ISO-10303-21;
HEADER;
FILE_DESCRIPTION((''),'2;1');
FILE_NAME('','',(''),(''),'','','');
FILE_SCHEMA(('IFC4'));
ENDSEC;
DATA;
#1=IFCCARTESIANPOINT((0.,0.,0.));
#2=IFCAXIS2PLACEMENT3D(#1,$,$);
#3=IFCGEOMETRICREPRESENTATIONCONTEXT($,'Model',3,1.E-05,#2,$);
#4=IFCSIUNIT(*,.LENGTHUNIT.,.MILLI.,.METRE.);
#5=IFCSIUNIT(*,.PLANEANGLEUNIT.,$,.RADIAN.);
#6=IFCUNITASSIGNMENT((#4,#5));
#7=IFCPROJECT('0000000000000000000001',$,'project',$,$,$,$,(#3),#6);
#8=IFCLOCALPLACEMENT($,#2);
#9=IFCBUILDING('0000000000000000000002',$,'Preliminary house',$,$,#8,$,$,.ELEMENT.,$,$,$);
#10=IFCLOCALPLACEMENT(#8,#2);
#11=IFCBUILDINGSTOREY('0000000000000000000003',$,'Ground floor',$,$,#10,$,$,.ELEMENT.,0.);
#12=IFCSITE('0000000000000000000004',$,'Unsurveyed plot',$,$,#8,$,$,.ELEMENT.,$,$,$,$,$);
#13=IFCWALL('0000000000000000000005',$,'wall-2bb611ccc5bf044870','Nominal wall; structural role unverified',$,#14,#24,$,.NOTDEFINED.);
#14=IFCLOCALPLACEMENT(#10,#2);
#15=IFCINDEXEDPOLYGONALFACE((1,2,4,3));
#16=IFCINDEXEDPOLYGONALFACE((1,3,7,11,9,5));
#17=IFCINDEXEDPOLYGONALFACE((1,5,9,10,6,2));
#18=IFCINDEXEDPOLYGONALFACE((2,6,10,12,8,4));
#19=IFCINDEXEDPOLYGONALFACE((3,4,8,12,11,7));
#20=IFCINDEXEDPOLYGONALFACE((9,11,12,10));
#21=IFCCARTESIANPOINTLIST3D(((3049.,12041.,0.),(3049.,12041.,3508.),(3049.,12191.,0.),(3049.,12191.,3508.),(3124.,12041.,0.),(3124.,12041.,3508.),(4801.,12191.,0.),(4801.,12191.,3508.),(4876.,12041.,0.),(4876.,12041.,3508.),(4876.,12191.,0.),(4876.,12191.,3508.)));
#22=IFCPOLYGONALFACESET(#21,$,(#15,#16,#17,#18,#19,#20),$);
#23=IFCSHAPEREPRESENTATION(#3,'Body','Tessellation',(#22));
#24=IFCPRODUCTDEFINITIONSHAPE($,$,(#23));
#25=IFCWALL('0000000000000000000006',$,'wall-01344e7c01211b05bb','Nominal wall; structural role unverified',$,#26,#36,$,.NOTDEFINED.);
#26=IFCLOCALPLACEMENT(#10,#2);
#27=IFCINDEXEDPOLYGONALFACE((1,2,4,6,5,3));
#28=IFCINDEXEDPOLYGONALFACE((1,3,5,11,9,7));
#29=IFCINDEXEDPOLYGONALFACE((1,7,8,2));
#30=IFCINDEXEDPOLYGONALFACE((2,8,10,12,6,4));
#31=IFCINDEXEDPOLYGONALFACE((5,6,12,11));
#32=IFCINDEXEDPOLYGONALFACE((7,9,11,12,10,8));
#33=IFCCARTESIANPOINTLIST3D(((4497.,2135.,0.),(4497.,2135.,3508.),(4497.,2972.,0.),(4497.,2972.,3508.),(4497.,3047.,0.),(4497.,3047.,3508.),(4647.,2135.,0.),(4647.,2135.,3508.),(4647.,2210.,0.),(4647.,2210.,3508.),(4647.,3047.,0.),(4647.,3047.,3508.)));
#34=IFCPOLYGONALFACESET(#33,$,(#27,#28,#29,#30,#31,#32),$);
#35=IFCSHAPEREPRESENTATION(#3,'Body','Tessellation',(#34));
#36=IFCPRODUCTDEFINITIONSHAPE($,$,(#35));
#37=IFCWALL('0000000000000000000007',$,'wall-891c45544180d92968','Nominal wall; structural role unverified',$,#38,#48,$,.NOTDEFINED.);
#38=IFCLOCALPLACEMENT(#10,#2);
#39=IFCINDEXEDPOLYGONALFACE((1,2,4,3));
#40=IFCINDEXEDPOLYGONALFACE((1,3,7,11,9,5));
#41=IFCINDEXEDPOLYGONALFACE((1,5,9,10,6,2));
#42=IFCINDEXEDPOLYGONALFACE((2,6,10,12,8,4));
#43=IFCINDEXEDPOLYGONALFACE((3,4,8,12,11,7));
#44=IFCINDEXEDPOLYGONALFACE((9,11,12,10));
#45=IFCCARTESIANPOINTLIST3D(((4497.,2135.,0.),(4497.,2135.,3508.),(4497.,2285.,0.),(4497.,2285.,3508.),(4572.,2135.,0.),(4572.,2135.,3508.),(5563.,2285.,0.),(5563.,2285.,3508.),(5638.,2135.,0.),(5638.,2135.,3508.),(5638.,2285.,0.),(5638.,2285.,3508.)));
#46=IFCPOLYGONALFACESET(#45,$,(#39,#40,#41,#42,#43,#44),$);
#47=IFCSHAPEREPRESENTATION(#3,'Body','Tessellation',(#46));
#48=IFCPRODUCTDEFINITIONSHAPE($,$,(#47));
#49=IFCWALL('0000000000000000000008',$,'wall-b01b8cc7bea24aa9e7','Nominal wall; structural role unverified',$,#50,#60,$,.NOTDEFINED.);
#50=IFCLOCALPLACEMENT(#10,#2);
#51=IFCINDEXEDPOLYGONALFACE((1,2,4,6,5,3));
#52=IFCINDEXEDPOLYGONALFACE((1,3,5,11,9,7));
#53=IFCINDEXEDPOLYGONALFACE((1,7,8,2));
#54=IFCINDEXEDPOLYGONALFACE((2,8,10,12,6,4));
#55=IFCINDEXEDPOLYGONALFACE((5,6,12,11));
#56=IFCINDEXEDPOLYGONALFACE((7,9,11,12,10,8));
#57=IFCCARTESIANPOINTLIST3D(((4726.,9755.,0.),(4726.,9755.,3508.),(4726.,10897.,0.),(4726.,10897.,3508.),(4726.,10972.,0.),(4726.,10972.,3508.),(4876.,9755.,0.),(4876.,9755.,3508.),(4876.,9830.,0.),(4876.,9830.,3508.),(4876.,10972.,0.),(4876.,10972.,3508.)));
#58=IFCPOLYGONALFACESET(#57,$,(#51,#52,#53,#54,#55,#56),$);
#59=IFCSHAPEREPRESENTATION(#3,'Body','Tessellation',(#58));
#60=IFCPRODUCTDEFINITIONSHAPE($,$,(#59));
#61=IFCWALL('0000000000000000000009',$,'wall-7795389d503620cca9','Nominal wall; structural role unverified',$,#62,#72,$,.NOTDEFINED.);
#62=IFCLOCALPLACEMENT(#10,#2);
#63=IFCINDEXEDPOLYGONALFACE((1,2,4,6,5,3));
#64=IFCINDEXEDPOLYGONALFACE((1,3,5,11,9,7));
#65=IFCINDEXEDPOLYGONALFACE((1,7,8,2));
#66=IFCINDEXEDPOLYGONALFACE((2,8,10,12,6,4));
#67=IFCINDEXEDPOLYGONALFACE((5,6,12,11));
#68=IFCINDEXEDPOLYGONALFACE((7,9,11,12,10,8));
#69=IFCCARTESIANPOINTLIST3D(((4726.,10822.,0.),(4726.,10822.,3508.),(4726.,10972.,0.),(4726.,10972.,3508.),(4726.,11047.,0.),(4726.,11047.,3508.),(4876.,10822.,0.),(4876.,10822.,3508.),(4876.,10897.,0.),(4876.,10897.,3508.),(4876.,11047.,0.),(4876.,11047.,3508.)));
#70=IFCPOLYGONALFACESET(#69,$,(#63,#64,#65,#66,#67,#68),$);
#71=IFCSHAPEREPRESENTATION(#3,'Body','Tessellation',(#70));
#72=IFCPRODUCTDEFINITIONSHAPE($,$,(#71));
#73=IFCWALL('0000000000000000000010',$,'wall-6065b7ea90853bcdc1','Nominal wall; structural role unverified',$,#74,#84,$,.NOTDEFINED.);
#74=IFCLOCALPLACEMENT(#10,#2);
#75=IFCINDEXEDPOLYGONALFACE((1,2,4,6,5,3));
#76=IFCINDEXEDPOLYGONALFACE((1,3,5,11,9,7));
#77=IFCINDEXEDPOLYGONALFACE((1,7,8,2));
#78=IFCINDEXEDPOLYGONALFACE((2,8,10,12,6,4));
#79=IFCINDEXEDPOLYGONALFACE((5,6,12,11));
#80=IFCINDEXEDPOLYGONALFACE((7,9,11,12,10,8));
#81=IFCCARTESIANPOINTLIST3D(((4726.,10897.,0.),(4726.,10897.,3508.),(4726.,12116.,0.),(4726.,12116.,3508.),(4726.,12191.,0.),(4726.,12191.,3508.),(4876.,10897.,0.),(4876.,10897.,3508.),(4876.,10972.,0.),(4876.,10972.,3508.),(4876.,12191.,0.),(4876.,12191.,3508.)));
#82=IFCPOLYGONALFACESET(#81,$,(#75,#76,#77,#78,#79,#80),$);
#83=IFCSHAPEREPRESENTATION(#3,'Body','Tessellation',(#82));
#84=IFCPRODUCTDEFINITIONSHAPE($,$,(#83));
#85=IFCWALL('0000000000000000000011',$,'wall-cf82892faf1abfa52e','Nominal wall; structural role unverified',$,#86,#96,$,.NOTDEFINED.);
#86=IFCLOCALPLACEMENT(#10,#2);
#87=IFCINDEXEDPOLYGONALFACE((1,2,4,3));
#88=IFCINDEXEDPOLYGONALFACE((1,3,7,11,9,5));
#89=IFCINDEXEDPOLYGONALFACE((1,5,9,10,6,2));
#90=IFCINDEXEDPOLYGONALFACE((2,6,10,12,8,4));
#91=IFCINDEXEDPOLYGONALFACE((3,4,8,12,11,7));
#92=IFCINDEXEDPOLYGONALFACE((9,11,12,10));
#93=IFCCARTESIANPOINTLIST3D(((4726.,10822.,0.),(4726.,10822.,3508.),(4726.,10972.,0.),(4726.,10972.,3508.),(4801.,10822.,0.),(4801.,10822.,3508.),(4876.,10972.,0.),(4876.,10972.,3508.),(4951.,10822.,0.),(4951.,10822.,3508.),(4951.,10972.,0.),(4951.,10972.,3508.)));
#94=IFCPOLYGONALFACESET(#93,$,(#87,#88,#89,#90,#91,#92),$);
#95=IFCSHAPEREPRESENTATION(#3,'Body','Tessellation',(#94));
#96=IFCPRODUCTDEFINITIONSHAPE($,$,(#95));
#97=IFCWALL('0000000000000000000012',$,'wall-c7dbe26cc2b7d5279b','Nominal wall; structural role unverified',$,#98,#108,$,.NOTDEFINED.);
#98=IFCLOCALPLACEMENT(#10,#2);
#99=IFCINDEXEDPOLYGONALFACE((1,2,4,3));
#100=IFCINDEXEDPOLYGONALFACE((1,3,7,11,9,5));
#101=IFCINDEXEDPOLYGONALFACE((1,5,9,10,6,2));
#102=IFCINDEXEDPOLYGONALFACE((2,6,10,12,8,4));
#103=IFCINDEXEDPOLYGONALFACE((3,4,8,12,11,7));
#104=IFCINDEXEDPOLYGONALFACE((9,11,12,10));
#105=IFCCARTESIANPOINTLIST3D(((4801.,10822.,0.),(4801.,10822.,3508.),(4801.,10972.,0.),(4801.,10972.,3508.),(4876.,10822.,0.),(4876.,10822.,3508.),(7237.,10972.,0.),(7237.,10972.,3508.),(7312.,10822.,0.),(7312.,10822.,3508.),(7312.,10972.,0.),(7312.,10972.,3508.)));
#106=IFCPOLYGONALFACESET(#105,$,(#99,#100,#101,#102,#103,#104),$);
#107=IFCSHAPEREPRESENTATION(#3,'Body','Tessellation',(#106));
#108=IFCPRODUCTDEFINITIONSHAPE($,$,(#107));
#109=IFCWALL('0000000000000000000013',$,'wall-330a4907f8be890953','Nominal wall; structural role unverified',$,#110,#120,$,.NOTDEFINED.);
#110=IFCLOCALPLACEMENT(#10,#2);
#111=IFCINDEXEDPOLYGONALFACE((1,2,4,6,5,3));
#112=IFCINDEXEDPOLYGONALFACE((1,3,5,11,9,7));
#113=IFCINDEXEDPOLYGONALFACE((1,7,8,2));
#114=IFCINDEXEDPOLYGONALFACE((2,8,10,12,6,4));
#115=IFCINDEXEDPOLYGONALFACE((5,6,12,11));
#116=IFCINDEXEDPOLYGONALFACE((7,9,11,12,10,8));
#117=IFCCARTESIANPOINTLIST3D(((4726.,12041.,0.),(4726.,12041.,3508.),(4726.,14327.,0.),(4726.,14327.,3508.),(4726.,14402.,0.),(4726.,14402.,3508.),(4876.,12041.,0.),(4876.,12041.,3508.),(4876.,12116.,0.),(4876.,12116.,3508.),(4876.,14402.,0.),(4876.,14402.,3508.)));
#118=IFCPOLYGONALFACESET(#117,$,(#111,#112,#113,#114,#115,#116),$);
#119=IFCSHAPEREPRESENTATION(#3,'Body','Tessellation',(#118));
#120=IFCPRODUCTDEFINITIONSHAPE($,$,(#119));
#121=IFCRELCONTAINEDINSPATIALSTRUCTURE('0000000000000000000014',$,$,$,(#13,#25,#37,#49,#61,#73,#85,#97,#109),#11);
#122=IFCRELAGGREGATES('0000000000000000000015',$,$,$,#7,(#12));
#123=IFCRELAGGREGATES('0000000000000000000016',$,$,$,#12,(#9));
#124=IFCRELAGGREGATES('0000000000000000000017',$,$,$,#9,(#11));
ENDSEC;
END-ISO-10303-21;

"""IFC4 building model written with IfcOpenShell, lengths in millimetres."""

from ifc_helpers import new_model, si_unit, origin, place, context, project, spatial, polyline, outline, extrude, element, save


model = new_model("IFC4")

# Units and contexts
model_context = context("Model", 3, precision=1e-05, world=origin())
ifc_project = project(units=[si_unit("LENGTHUNIT", "METRE", prefix="MILLI"), si_unit("PLANEANGLEUNIT", "RADIAN")], contexts=[model_context])

# Site, building, storey
placement_1 = place(None, origin())
site = spatial("IfcSite", under=ifc_project, at=placement_1, Name="Unsurveyed plot", CompositionType="ELEMENT")
building = spatial("IfcBuilding", under=site, at=placement_1, Name="Preliminary house", CompositionType="ELEMENT")
placement_2 = place(placement_1, origin())
storey = spatial("IfcBuildingStorey", under=building, at=placement_2, Name="Ground floor", CompositionType="ELEMENT", Elevation=0.0)

# Wall
element("IfcWall", 1, at=placement_2, inside=storey, Name="wall-2bb611ccc5bf044870", Description="Nominal wall; structural role unverified", PredefinedType="NOTDEFINED", context=model_context, shape_type="SweptSolid", body=[
    extrude(outline(polyline([(4801.0, 12191.0), (4876.0, 12191.0), (4876.0, 12041.0), (3124.0, 12041.0), (3049.0, 12041.0), (3049.0, 12191.0), (4801.0, 12191.0)])), origin(), (0.0, 0.0, 1.0), 3508.0),
])

# Walls
element("IfcWall", 2, at=placement_2, inside=storey, Name="wall-01344e7c01211b05bb", Description="Nominal wall; structural role unverified", PredefinedType="NOTDEFINED", context=model_context, shape_type="SweptSolid", body=[
    extrude(outline(polyline([(4497.0, 2972.0), (4497.0, 3047.0), (4647.0, 3047.0), (4647.0, 2210.0), (4647.0, 2135.0), (4497.0, 2135.0), (4497.0, 2972.0)])), origin(), (0.0, 0.0, 1.0), 3508.0),
])
element("IfcWall", 3, at=placement_2, inside=storey, Name="wall-891c45544180d92968", Description="Nominal wall; structural role unverified", PredefinedType="NOTDEFINED", context=model_context, shape_type="SweptSolid", body=[
    extrude(outline(polyline([(5563.0, 2285.0), (5638.0, 2285.0), (5638.0, 2135.0), (4572.0, 2135.0), (4497.0, 2135.0), (4497.0, 2285.0), (5563.0, 2285.0)])), origin(), (0.0, 0.0, 1.0), 3508.0),
])
element("IfcWall", 4, at=placement_2, inside=storey, Name="wall-b01b8cc7bea24aa9e7", Description="Nominal wall; structural role unverified", PredefinedType="NOTDEFINED", context=model_context, shape_type="SweptSolid", body=[
    extrude(outline(polyline([(4726.0, 10897.0), (4726.0, 10972.0), (4876.0, 10972.0), (4876.0, 9830.0), (4876.0, 9755.0), (4726.0, 9755.0), (4726.0, 10897.0)])), origin(), (0.0, 0.0, 1.0), 3508.0),
])

# Walls
element("IfcWall", 5, at=placement_2, inside=storey, Name="wall-7795389d503620cca9", Description="Nominal wall; structural role unverified", PredefinedType="NOTDEFINED", context=model_context, shape_type="SweptSolid", body=[
    extrude(outline(polyline([(4726.0, 10972.0), (4726.0, 11047.0), (4876.0, 11047.0), (4876.0, 10897.0), (4876.0, 10822.0), (4726.0, 10822.0), (4726.0, 10972.0)])), origin(), (0.0, 0.0, 1.0), 3508.0),
])
element("IfcWall", 6, at=placement_2, inside=storey, Name="wall-6065b7ea90853bcdc1", Description="Nominal wall; structural role unverified", PredefinedType="NOTDEFINED", context=model_context, shape_type="SweptSolid", body=[
    extrude(outline(polyline([(4726.0, 12116.0), (4726.0, 12191.0), (4876.0, 12191.0), (4876.0, 10972.0), (4876.0, 10897.0), (4726.0, 10897.0), (4726.0, 12116.0)])), origin(), (0.0, 0.0, 1.0), 3508.0),
])
element("IfcWall", 7, at=placement_2, inside=storey, Name="wall-cf82892faf1abfa52e", Description="Nominal wall; structural role unverified", PredefinedType="NOTDEFINED", context=model_context, shape_type="SweptSolid", body=[
    extrude(outline(polyline([(4876.0, 10972.0), (4951.0, 10972.0), (4951.0, 10822.0), (4801.0, 10822.0), (4726.0, 10822.0), (4726.0, 10972.0), (4876.0, 10972.0)])), origin(), (0.0, 0.0, 1.0), 3508.0),
])
element("IfcWall", 8, at=placement_2, inside=storey, Name="wall-c7dbe26cc2b7d5279b", Description="Nominal wall; structural role unverified", PredefinedType="NOTDEFINED", context=model_context, shape_type="SweptSolid", body=[
    extrude(outline(polyline([(7237.0, 10972.0), (7312.0, 10972.0), (7312.0, 10822.0), (4876.0, 10822.0), (4801.0, 10822.0), (4801.0, 10972.0), (7237.0, 10972.0)])), origin(), (0.0, 0.0, 1.0), 3508.0),
])
element("IfcWall", 9, at=placement_2, inside=storey, Name="wall-330a4907f8be890953", Description="Nominal wall; structural role unverified", PredefinedType="NOTDEFINED", context=model_context, shape_type="SweptSolid", body=[
    extrude(outline(polyline([(4726.0, 14327.0), (4726.0, 14402.0), (4876.0, 14402.0), (4876.0, 12116.0), (4876.0, 12041.0), (4726.0, 12041.0), (4726.0, 14327.0)])), origin(), (0.0, 0.0, 1.0), 3508.0),
])

save(model, "model.ifc")
